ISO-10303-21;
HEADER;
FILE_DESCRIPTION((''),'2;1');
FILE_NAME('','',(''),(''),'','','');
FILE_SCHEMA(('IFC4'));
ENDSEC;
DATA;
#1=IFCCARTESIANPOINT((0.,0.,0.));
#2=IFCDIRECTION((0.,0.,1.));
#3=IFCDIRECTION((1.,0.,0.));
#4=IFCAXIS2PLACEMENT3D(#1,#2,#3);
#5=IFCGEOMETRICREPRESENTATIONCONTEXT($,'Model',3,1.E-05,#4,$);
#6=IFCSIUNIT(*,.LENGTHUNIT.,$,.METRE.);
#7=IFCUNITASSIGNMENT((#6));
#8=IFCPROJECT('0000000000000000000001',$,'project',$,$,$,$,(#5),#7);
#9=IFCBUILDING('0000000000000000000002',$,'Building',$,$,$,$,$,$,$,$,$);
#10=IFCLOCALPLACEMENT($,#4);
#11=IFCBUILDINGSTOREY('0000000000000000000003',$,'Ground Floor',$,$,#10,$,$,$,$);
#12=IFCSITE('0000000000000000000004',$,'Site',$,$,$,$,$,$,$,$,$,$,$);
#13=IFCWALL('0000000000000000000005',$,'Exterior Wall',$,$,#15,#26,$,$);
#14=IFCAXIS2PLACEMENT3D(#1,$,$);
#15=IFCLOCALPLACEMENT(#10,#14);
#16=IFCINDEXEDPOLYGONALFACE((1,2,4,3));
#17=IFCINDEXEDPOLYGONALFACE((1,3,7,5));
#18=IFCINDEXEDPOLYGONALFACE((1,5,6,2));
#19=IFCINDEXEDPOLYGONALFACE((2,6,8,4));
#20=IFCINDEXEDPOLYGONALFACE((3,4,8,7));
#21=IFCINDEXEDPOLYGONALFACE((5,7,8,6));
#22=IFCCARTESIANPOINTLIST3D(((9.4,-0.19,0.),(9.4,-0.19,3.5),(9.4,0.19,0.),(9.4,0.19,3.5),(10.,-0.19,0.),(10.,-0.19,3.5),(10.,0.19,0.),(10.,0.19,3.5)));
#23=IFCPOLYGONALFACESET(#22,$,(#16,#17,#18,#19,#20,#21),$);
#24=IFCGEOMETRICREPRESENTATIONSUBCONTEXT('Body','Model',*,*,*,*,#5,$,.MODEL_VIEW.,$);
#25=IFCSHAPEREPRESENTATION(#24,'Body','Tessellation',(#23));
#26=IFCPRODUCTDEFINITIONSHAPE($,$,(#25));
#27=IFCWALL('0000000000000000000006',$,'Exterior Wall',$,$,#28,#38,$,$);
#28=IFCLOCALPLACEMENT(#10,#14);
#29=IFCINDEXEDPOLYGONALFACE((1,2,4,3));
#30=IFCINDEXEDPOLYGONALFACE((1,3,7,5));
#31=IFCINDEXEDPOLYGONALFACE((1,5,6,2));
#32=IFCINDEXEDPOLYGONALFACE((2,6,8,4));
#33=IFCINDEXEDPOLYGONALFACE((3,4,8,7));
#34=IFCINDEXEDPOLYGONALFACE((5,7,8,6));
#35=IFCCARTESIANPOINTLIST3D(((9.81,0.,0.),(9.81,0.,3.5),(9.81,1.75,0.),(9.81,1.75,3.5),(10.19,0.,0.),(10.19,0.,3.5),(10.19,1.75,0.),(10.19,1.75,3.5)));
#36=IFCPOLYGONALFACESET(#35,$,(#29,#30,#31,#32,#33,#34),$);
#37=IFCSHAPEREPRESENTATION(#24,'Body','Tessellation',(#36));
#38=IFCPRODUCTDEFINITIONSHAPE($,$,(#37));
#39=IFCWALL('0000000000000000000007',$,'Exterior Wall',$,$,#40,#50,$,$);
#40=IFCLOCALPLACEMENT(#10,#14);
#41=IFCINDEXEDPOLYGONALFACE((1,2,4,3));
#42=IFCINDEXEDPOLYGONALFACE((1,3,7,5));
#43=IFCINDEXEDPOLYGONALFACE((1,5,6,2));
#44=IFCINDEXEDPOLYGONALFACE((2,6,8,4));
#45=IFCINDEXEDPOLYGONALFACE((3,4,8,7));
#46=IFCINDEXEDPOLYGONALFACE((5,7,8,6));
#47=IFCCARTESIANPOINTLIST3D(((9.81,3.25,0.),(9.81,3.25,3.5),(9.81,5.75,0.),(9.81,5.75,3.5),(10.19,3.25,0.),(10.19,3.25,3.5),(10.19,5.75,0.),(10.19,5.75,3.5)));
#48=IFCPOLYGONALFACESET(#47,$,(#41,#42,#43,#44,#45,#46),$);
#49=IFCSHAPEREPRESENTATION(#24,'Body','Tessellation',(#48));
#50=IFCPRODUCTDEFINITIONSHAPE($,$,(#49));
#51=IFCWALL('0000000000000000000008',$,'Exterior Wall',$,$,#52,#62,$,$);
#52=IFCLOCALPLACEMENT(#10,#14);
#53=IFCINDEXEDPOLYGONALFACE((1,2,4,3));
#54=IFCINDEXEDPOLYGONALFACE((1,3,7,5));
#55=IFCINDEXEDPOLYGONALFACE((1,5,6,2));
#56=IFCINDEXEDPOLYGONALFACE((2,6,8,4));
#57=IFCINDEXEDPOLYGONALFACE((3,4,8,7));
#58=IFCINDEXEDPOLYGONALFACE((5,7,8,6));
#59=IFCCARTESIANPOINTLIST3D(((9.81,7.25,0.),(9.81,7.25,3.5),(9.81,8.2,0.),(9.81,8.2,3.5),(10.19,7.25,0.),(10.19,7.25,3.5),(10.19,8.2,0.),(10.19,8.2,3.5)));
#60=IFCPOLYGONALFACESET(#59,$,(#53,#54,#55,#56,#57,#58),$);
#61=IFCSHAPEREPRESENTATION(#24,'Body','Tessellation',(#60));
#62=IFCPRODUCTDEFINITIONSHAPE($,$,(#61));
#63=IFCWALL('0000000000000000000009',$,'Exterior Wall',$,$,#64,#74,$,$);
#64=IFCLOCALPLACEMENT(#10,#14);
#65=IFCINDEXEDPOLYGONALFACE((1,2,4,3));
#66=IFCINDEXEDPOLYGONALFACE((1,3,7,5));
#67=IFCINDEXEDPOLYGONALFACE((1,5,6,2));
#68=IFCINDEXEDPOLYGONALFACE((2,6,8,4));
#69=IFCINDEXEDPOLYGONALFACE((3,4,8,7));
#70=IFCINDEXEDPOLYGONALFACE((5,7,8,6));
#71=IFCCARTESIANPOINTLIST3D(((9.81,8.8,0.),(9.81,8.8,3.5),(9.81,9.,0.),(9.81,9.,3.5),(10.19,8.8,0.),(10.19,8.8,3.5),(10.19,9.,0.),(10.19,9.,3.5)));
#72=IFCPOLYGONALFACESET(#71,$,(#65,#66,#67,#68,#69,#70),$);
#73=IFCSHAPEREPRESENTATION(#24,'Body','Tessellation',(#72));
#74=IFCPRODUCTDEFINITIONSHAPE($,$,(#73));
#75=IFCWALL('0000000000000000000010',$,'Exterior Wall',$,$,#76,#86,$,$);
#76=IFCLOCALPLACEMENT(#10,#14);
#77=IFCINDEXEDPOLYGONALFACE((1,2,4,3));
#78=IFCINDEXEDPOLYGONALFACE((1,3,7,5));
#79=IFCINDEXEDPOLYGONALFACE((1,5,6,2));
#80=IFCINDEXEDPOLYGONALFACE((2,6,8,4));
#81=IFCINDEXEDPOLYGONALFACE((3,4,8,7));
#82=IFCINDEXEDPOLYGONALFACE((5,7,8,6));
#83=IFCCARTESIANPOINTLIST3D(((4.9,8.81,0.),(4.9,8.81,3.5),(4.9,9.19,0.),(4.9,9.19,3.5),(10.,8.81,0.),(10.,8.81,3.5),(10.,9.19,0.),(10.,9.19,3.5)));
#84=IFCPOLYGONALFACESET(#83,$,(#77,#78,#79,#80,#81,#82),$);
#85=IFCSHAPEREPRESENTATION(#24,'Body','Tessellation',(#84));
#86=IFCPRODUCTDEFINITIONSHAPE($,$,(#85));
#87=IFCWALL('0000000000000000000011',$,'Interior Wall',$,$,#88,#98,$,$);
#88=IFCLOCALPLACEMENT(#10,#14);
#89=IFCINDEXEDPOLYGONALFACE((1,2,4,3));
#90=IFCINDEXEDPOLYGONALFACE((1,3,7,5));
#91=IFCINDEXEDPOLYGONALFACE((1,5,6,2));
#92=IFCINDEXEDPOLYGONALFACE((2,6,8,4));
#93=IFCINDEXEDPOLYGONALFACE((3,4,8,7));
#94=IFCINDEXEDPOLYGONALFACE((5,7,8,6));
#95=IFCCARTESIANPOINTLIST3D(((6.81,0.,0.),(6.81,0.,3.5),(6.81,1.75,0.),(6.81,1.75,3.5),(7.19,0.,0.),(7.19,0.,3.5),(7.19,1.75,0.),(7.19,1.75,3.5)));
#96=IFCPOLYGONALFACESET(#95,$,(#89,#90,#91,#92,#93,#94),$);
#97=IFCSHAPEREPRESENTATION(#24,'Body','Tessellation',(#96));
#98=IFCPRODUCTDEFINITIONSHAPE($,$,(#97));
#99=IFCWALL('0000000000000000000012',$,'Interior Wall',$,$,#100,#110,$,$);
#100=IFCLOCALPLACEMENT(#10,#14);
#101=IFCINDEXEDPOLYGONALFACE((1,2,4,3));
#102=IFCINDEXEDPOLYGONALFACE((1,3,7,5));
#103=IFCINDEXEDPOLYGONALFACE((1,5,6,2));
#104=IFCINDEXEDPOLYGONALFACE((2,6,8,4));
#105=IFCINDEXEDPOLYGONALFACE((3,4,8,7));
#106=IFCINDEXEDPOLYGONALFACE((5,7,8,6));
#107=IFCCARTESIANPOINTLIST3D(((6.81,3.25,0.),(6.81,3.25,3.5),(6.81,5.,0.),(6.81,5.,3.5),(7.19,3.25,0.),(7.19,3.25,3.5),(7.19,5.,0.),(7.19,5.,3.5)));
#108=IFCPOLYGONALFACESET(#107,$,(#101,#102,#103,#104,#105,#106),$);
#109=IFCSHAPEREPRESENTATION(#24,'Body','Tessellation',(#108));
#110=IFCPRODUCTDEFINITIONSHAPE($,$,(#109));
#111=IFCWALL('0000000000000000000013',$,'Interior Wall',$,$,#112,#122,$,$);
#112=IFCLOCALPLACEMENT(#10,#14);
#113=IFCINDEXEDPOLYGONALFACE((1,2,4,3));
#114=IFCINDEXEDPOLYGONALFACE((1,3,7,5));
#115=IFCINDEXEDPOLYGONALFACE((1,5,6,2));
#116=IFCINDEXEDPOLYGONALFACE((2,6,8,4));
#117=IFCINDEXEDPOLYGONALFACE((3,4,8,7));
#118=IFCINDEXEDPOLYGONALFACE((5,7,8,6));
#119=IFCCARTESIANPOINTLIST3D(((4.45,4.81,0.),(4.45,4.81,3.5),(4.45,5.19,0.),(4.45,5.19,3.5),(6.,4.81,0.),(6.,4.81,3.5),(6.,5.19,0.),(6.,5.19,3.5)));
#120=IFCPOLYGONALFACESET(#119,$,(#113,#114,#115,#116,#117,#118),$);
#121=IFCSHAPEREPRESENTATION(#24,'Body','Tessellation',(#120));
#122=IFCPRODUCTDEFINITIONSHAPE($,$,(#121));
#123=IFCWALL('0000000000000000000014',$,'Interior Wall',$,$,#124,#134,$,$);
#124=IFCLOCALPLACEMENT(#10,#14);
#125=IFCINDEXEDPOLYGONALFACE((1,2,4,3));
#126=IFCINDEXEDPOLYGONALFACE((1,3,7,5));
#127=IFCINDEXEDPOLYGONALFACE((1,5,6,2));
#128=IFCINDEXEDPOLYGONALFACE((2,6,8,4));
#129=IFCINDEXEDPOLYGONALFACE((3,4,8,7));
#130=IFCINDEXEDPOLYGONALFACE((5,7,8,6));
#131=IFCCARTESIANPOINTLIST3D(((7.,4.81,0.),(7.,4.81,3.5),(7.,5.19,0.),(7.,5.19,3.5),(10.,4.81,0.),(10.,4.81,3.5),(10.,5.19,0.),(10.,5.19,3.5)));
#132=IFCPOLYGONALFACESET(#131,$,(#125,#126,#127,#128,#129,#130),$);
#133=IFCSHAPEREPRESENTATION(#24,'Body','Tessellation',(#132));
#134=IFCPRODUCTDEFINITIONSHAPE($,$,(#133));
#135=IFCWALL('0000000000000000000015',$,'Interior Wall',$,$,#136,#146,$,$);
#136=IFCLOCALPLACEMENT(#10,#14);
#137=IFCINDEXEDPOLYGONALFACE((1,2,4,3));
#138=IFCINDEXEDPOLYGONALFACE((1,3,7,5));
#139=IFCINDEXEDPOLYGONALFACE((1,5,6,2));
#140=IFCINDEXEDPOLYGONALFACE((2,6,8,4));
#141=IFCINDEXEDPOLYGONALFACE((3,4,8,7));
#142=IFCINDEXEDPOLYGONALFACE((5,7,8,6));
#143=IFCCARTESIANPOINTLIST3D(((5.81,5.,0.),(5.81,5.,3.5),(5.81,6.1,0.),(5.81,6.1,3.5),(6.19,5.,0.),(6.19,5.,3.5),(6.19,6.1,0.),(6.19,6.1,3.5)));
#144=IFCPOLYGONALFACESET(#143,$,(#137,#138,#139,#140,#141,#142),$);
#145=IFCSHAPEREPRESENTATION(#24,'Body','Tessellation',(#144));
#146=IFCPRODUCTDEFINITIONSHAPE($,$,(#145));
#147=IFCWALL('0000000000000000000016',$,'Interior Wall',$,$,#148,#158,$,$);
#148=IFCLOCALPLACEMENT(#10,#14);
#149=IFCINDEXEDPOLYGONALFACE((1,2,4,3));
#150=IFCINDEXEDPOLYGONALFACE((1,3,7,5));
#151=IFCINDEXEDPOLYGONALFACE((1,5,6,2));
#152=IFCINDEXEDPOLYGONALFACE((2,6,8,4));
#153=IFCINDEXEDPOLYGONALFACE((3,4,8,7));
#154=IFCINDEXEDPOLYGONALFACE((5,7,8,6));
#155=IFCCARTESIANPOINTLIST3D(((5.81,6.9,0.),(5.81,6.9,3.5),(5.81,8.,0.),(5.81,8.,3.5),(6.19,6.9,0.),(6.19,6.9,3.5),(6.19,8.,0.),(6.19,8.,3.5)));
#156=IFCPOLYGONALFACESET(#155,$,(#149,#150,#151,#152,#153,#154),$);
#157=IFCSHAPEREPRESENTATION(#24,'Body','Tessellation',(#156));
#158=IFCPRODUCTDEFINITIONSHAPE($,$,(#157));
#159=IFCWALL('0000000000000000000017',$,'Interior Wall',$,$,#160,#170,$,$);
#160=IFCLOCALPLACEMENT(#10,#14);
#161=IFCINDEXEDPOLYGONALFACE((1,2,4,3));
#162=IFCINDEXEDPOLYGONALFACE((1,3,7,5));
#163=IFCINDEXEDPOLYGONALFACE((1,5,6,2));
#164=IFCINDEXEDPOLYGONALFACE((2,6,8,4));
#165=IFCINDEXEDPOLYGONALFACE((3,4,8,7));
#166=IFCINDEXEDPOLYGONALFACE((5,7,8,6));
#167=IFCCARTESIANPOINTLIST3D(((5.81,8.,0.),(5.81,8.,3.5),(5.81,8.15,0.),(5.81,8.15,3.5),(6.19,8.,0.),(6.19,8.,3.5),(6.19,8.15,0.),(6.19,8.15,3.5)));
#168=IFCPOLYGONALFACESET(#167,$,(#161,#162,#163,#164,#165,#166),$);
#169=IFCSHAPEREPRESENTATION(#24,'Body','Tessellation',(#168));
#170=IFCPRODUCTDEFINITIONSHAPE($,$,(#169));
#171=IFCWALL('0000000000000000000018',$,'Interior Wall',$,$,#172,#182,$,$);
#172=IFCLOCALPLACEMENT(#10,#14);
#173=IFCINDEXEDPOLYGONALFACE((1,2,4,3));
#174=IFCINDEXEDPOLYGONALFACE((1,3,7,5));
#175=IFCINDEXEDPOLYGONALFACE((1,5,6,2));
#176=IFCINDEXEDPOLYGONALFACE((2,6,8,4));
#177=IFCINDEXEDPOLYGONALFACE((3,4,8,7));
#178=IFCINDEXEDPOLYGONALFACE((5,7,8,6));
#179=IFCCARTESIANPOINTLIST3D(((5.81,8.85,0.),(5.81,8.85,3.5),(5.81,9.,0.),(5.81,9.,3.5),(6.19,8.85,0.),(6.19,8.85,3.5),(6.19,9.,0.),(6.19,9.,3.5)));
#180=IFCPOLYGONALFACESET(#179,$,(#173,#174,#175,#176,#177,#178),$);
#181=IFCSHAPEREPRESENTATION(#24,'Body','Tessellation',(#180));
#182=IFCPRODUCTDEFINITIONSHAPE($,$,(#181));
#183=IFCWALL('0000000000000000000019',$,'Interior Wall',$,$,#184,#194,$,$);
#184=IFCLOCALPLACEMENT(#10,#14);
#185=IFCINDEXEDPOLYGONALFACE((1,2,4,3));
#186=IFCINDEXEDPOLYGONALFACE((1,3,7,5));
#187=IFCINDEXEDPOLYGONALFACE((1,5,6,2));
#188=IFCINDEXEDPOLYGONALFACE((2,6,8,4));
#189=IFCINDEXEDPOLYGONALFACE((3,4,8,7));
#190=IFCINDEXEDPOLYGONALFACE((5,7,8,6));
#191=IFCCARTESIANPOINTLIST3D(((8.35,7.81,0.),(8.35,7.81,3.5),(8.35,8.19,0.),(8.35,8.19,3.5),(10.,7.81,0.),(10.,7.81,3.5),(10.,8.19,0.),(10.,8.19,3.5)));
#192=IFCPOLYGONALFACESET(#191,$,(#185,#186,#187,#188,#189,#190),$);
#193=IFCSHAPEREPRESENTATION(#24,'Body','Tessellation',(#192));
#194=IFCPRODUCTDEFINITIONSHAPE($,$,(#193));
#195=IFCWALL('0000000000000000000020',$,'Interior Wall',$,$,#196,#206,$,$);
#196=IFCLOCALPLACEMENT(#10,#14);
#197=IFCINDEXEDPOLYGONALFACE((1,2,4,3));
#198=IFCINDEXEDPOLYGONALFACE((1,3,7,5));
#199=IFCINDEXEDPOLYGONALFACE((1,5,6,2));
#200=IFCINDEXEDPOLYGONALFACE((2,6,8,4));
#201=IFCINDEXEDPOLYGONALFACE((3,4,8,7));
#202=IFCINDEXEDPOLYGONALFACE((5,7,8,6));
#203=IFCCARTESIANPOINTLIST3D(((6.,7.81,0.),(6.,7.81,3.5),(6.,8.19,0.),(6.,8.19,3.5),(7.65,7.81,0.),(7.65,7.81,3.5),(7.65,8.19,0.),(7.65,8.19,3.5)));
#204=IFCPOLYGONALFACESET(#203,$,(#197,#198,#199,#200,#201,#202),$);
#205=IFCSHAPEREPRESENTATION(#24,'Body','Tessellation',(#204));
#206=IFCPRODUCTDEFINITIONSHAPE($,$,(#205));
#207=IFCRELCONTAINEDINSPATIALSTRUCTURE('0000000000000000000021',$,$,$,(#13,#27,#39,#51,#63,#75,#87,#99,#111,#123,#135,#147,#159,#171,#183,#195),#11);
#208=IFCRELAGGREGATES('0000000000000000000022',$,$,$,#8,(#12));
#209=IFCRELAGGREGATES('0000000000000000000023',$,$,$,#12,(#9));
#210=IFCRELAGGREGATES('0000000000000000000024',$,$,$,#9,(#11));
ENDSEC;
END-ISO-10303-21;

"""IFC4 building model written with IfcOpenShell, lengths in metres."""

from ifc_helpers import new_model, si_unit, frame, origin_with_axes, place, context, subcontext, project, spatial, indexed_curve, outline, extrude, element, save


model = new_model("IFC4")

# Units and contexts
model_context = context("Model", 3, precision=1e-05, world=origin_with_axes())
body_context = subcontext(model_context, "Body", "Model", "MODEL_VIEW")
ifc_project = project(units=[si_unit("LENGTHUNIT", "METRE")], contexts=[model_context])

# Site, building, storey
site = spatial("IfcSite", under=ifc_project, Name="Site")
building = spatial("IfcBuilding", under=site, Name="Building")
storey_placement = place(None, origin_with_axes())
storey = spatial("IfcBuildingStorey", under=building, at=storey_placement, Name="Ground Floor")

# Walls
wall_1_placement = place(storey_placement, frame((9.4, 0.0, 0.0), z_axis=(0.0, 0.0, 1.0), x_axis=(1.0, 0.0, 0.0)))
element("IfcWall", 1, at=wall_1_placement, inside=storey, Name="Exterior Wall", context=body_context, shape_type="SweptSolid", body=[
    extrude(outline(indexed_curve([(0.0, 0.0), (0.0, 0.38), (0.6, 0.38), (0.6, 0.0), (0.0, 0.0)], self_intersect=False)), frame((0.0, -0.19, 0.0), z_axis=(0.0, 0.0, 1.0), x_axis=(1.0, 0.0, 0.0)), (0.0, 0.0, 1.0), 3.5),
])
wall_2_placement = place(storey_placement, frame((10.0, 0.0, 0.0), z_axis=(0.0, 0.0, 1.0), x_axis=(0.0, 1.0, 0.0)))
element("IfcWall", 2, at=wall_2_placement, inside=storey, Name="Exterior Wall", context=body_context, shape_type="SweptSolid", body=[
    extrude(outline(indexed_curve([(0.0, 0.0), (0.0, 0.38), (1.75, 0.38), (1.75, 0.0), (0.0, 0.0)], self_intersect=False)), frame((0.0, -0.19, 0.0), z_axis=(0.0, 0.0, 1.0), x_axis=(1.0, 0.0, 0.0)), (0.0, 0.0, 1.0), 3.5),
])
wall_3_placement = place(storey_placement, frame((10.0, 3.25, 0.0), z_axis=(0.0, 0.0, 1.0), x_axis=(0.0, 1.0, 0.0)))
element("IfcWall", 3, at=wall_3_placement, inside=storey, Name="Exterior Wall", context=body_context, shape_type="SweptSolid", body=[
    extrude(outline(indexed_curve([(0.0, 0.0), (0.0, 0.38), (2.5, 0.38), (2.5, 0.0), (0.0, 0.0)], self_intersect=False)), frame((0.0, -0.19, 0.0), z_axis=(0.0, 0.0, 1.0), x_axis=(1.0, 0.0, 0.0)), (0.0, 0.0, 1.0), 3.5),
])
wall_4_placement = place(storey_placement, frame((10.0, 7.25, 0.0), z_axis=(0.0, 0.0, 1.0), x_axis=(0.0, 1.0, 0.0)))
element("IfcWall", 4, at=wall_4_placement, inside=storey, Name="Exterior Wall", context=body_context, shape_type="SweptSolid", body=[
    extrude(outline(indexed_curve([(0.0, 0.0), (0.0, 0.38), (0.95, 0.38), (0.95, 0.0), (0.0, 0.0)], self_intersect=False)), frame((0.0, -0.19, 0.0), z_axis=(0.0, 0.0, 1.0), x_axis=(1.0, 0.0, 0.0)), (0.0, 0.0, 1.0), 3.5),
])
wall_5_placement = place(storey_placement, frame((10.0, 8.8, 0.0), z_axis=(0.0, 0.0, 1.0), x_axis=(0.0, 1.0, 0.0)))
element("IfcWall", 5, at=wall_5_placement, inside=storey, Name="Exterior Wall", context=body_context, shape_type="SweptSolid", body=[
    extrude(outline(indexed_curve([(0.0, 0.0), (0.0, 0.38), (0.2, 0.38), (0.2, 0.0), (0.0, 0.0)], self_intersect=False)), frame((0.0, -0.19, 0.0), z_axis=(0.0, 0.0, 1.0), x_axis=(1.0, 0.0, 0.0)), (0.0, 0.0, 1.0), 3.5),
])
wall_6_placement = place(storey_placement, frame((10.0, 9.0, 0.0), z_axis=(0.0, 0.0, 1.0), x_axis=(-1.0, 0.0, 0.0)))
element("IfcWall", 6, at=wall_6_placement, inside=storey, Name="Exterior Wall", context=body_context, shape_type="SweptSolid", body=[
    extrude(outline(indexed_curve([(0.0, 0.0), (0.0, 0.38), (5.1, 0.38), (5.1, 0.0), (0.0, 0.0)], self_intersect=False)), frame((0.0, -0.19, 0.0), z_axis=(0.0, 0.0, 1.0), x_axis=(1.0, 0.0, 0.0)), (0.0, 0.0, 1.0), 3.5),
])
for number, where, z_axis, x_axis, name in (
    (7, (7.0, 0.0, 0.0), (0.0, 0.0, 1.0), (0.0, 1.0, 0.0), "Interior Wall"),
    (8, (7.0, 3.25, 0.0), (0.0, 0.0, 1.0), (0.0, 1.0, 0.0), "Interior Wall"),
):
    element("IfcWall", number, at=place(storey_placement, frame(where, z_axis=z_axis, x_axis=x_axis)), inside=storey, Name=name, context=body_context, shape_type="SweptSolid", body=[
        extrude(outline(indexed_curve([(0.0, 0.0), (0.0, 0.38), (1.75, 0.38), (1.75, 0.0), (0.0, 0.0)], self_intersect=False)), frame((0.0, -0.19, 0.0), z_axis=(0.0, 0.0, 1.0), x_axis=(1.0, 0.0, 0.0)), (0.0, 0.0, 1.0), 3.5),
    ])
wall_7_placement = place(storey_placement, frame((6.0, 5.0, 0.0), z_axis=(0.0, 0.0, 1.0), x_axis=(-1.0, 0.0, 0.0)))
element("IfcWall", 9, at=wall_7_placement, inside=storey, Name="Interior Wall", context=body_context, shape_type="SweptSolid", body=[
    extrude(outline(indexed_curve([(0.0, 0.0), (0.0, 0.38), (1.55, 0.38), (1.55, 0.0), (0.0, 0.0)], self_intersect=False)), frame((0.0, -0.19, 0.0), z_axis=(0.0, 0.0, 1.0), x_axis=(1.0, 0.0, 0.0)), (0.0, 0.0, 1.0), 3.5),
])
wall_8_placement = place(storey_placement, frame((10.0, 5.0, 0.0), z_axis=(0.0, 0.0, 1.0), x_axis=(-1.0, 0.0, 0.0)))
element("IfcWall", 10, at=wall_8_placement, inside=storey, Name="Interior Wall", context=body_context, shape_type="SweptSolid", body=[
    extrude(outline(indexed_curve([(0.0, 0.0), (0.0, 0.38), (3.0, 0.38), (3.0, 0.0), (0.0, 0.0)], self_intersect=False)), frame((0.0, -0.19, 0.0), z_axis=(0.0, 0.0, 1.0), x_axis=(1.0, 0.0, 0.0)), (0.0, 0.0, 1.0), 3.5),
])
for number, where, z_axis, x_axis, name in (
    (11, (6.0, 5.0, 0.0), (0.0, 0.0, 1.0), (0.0, 1.0, 0.0), "Interior Wall"),
    (12, (6.0, 6.9, 0.0), (0.0, 0.0, 1.0), (0.0, 1.0, 0.0), "Interior Wall"),
):
    element("IfcWall", number, at=place(storey_placement, frame(where, z_axis=z_axis, x_axis=x_axis)), inside=storey, Name=name, context=body_context, shape_type="SweptSolid", body=[
        extrude(outline(indexed_curve([(0.0, 0.0), (0.0, 0.38), (1.1, 0.38), (1.1, 0.0), (0.0, 0.0)], self_intersect=False)), frame((0.0, -0.19, 0.0), z_axis=(0.0, 0.0, 1.0), x_axis=(1.0, 0.0, 0.0)), (0.0, 0.0, 1.0), 3.5),
    ])
for number, where, z_axis, x_axis, name in (
    (13, (6.0, 8.0, 0.0), (0.0, 0.0, 1.0), (0.0, 1.0, 0.0), "Interior Wall"),
    (14, (6.0, 8.85, 0.0), (0.0, 0.0, 1.0), (0.0, 1.0, 0.0), "Interior Wall"),
):
    element("IfcWall", number, at=place(storey_placement, frame(where, z_axis=z_axis, x_axis=x_axis)), inside=storey, Name=name, context=body_context, shape_type="SweptSolid", body=[
        extrude(outline(indexed_curve([(0.0, 0.0), (0.0, 0.38), (0.15, 0.38), (0.15, 0.0), (0.0, 0.0)], self_intersect=False)), frame((0.0, -0.19, 0.0), z_axis=(0.0, 0.0, 1.0), x_axis=(1.0, 0.0, 0.0)), (0.0, 0.0, 1.0), 3.5),
    ])
for number, where, z_axis, x_axis, name in (
    (15, (10.0, 8.0, 0.0), (0.0, 0.0, 1.0), (-1.0, 0.0, 0.0), "Interior Wall"),
    (16, (7.65, 8.0, 0.0), (0.0, 0.0, 1.0), (-1.0, 0.0, 0.0), "Interior Wall"),
):
    element("IfcWall", number, at=place(storey_placement, frame(where, z_axis=z_axis, x_axis=x_axis)), inside=storey, Name=name, context=body_context, shape_type="SweptSolid", body=[
        extrude(outline(indexed_curve([(0.0, 0.0), (0.0, 0.38), (1.65, 0.38), (1.65, 0.0), (0.0, 0.0)], self_intersect=False)), frame((0.0, -0.19, 0.0), z_axis=(0.0, 0.0, 1.0), x_axis=(1.0, 0.0, 0.0)), (0.0, 0.0, 1.0), 3.5),
    ])

save(model, "model.ifc")
